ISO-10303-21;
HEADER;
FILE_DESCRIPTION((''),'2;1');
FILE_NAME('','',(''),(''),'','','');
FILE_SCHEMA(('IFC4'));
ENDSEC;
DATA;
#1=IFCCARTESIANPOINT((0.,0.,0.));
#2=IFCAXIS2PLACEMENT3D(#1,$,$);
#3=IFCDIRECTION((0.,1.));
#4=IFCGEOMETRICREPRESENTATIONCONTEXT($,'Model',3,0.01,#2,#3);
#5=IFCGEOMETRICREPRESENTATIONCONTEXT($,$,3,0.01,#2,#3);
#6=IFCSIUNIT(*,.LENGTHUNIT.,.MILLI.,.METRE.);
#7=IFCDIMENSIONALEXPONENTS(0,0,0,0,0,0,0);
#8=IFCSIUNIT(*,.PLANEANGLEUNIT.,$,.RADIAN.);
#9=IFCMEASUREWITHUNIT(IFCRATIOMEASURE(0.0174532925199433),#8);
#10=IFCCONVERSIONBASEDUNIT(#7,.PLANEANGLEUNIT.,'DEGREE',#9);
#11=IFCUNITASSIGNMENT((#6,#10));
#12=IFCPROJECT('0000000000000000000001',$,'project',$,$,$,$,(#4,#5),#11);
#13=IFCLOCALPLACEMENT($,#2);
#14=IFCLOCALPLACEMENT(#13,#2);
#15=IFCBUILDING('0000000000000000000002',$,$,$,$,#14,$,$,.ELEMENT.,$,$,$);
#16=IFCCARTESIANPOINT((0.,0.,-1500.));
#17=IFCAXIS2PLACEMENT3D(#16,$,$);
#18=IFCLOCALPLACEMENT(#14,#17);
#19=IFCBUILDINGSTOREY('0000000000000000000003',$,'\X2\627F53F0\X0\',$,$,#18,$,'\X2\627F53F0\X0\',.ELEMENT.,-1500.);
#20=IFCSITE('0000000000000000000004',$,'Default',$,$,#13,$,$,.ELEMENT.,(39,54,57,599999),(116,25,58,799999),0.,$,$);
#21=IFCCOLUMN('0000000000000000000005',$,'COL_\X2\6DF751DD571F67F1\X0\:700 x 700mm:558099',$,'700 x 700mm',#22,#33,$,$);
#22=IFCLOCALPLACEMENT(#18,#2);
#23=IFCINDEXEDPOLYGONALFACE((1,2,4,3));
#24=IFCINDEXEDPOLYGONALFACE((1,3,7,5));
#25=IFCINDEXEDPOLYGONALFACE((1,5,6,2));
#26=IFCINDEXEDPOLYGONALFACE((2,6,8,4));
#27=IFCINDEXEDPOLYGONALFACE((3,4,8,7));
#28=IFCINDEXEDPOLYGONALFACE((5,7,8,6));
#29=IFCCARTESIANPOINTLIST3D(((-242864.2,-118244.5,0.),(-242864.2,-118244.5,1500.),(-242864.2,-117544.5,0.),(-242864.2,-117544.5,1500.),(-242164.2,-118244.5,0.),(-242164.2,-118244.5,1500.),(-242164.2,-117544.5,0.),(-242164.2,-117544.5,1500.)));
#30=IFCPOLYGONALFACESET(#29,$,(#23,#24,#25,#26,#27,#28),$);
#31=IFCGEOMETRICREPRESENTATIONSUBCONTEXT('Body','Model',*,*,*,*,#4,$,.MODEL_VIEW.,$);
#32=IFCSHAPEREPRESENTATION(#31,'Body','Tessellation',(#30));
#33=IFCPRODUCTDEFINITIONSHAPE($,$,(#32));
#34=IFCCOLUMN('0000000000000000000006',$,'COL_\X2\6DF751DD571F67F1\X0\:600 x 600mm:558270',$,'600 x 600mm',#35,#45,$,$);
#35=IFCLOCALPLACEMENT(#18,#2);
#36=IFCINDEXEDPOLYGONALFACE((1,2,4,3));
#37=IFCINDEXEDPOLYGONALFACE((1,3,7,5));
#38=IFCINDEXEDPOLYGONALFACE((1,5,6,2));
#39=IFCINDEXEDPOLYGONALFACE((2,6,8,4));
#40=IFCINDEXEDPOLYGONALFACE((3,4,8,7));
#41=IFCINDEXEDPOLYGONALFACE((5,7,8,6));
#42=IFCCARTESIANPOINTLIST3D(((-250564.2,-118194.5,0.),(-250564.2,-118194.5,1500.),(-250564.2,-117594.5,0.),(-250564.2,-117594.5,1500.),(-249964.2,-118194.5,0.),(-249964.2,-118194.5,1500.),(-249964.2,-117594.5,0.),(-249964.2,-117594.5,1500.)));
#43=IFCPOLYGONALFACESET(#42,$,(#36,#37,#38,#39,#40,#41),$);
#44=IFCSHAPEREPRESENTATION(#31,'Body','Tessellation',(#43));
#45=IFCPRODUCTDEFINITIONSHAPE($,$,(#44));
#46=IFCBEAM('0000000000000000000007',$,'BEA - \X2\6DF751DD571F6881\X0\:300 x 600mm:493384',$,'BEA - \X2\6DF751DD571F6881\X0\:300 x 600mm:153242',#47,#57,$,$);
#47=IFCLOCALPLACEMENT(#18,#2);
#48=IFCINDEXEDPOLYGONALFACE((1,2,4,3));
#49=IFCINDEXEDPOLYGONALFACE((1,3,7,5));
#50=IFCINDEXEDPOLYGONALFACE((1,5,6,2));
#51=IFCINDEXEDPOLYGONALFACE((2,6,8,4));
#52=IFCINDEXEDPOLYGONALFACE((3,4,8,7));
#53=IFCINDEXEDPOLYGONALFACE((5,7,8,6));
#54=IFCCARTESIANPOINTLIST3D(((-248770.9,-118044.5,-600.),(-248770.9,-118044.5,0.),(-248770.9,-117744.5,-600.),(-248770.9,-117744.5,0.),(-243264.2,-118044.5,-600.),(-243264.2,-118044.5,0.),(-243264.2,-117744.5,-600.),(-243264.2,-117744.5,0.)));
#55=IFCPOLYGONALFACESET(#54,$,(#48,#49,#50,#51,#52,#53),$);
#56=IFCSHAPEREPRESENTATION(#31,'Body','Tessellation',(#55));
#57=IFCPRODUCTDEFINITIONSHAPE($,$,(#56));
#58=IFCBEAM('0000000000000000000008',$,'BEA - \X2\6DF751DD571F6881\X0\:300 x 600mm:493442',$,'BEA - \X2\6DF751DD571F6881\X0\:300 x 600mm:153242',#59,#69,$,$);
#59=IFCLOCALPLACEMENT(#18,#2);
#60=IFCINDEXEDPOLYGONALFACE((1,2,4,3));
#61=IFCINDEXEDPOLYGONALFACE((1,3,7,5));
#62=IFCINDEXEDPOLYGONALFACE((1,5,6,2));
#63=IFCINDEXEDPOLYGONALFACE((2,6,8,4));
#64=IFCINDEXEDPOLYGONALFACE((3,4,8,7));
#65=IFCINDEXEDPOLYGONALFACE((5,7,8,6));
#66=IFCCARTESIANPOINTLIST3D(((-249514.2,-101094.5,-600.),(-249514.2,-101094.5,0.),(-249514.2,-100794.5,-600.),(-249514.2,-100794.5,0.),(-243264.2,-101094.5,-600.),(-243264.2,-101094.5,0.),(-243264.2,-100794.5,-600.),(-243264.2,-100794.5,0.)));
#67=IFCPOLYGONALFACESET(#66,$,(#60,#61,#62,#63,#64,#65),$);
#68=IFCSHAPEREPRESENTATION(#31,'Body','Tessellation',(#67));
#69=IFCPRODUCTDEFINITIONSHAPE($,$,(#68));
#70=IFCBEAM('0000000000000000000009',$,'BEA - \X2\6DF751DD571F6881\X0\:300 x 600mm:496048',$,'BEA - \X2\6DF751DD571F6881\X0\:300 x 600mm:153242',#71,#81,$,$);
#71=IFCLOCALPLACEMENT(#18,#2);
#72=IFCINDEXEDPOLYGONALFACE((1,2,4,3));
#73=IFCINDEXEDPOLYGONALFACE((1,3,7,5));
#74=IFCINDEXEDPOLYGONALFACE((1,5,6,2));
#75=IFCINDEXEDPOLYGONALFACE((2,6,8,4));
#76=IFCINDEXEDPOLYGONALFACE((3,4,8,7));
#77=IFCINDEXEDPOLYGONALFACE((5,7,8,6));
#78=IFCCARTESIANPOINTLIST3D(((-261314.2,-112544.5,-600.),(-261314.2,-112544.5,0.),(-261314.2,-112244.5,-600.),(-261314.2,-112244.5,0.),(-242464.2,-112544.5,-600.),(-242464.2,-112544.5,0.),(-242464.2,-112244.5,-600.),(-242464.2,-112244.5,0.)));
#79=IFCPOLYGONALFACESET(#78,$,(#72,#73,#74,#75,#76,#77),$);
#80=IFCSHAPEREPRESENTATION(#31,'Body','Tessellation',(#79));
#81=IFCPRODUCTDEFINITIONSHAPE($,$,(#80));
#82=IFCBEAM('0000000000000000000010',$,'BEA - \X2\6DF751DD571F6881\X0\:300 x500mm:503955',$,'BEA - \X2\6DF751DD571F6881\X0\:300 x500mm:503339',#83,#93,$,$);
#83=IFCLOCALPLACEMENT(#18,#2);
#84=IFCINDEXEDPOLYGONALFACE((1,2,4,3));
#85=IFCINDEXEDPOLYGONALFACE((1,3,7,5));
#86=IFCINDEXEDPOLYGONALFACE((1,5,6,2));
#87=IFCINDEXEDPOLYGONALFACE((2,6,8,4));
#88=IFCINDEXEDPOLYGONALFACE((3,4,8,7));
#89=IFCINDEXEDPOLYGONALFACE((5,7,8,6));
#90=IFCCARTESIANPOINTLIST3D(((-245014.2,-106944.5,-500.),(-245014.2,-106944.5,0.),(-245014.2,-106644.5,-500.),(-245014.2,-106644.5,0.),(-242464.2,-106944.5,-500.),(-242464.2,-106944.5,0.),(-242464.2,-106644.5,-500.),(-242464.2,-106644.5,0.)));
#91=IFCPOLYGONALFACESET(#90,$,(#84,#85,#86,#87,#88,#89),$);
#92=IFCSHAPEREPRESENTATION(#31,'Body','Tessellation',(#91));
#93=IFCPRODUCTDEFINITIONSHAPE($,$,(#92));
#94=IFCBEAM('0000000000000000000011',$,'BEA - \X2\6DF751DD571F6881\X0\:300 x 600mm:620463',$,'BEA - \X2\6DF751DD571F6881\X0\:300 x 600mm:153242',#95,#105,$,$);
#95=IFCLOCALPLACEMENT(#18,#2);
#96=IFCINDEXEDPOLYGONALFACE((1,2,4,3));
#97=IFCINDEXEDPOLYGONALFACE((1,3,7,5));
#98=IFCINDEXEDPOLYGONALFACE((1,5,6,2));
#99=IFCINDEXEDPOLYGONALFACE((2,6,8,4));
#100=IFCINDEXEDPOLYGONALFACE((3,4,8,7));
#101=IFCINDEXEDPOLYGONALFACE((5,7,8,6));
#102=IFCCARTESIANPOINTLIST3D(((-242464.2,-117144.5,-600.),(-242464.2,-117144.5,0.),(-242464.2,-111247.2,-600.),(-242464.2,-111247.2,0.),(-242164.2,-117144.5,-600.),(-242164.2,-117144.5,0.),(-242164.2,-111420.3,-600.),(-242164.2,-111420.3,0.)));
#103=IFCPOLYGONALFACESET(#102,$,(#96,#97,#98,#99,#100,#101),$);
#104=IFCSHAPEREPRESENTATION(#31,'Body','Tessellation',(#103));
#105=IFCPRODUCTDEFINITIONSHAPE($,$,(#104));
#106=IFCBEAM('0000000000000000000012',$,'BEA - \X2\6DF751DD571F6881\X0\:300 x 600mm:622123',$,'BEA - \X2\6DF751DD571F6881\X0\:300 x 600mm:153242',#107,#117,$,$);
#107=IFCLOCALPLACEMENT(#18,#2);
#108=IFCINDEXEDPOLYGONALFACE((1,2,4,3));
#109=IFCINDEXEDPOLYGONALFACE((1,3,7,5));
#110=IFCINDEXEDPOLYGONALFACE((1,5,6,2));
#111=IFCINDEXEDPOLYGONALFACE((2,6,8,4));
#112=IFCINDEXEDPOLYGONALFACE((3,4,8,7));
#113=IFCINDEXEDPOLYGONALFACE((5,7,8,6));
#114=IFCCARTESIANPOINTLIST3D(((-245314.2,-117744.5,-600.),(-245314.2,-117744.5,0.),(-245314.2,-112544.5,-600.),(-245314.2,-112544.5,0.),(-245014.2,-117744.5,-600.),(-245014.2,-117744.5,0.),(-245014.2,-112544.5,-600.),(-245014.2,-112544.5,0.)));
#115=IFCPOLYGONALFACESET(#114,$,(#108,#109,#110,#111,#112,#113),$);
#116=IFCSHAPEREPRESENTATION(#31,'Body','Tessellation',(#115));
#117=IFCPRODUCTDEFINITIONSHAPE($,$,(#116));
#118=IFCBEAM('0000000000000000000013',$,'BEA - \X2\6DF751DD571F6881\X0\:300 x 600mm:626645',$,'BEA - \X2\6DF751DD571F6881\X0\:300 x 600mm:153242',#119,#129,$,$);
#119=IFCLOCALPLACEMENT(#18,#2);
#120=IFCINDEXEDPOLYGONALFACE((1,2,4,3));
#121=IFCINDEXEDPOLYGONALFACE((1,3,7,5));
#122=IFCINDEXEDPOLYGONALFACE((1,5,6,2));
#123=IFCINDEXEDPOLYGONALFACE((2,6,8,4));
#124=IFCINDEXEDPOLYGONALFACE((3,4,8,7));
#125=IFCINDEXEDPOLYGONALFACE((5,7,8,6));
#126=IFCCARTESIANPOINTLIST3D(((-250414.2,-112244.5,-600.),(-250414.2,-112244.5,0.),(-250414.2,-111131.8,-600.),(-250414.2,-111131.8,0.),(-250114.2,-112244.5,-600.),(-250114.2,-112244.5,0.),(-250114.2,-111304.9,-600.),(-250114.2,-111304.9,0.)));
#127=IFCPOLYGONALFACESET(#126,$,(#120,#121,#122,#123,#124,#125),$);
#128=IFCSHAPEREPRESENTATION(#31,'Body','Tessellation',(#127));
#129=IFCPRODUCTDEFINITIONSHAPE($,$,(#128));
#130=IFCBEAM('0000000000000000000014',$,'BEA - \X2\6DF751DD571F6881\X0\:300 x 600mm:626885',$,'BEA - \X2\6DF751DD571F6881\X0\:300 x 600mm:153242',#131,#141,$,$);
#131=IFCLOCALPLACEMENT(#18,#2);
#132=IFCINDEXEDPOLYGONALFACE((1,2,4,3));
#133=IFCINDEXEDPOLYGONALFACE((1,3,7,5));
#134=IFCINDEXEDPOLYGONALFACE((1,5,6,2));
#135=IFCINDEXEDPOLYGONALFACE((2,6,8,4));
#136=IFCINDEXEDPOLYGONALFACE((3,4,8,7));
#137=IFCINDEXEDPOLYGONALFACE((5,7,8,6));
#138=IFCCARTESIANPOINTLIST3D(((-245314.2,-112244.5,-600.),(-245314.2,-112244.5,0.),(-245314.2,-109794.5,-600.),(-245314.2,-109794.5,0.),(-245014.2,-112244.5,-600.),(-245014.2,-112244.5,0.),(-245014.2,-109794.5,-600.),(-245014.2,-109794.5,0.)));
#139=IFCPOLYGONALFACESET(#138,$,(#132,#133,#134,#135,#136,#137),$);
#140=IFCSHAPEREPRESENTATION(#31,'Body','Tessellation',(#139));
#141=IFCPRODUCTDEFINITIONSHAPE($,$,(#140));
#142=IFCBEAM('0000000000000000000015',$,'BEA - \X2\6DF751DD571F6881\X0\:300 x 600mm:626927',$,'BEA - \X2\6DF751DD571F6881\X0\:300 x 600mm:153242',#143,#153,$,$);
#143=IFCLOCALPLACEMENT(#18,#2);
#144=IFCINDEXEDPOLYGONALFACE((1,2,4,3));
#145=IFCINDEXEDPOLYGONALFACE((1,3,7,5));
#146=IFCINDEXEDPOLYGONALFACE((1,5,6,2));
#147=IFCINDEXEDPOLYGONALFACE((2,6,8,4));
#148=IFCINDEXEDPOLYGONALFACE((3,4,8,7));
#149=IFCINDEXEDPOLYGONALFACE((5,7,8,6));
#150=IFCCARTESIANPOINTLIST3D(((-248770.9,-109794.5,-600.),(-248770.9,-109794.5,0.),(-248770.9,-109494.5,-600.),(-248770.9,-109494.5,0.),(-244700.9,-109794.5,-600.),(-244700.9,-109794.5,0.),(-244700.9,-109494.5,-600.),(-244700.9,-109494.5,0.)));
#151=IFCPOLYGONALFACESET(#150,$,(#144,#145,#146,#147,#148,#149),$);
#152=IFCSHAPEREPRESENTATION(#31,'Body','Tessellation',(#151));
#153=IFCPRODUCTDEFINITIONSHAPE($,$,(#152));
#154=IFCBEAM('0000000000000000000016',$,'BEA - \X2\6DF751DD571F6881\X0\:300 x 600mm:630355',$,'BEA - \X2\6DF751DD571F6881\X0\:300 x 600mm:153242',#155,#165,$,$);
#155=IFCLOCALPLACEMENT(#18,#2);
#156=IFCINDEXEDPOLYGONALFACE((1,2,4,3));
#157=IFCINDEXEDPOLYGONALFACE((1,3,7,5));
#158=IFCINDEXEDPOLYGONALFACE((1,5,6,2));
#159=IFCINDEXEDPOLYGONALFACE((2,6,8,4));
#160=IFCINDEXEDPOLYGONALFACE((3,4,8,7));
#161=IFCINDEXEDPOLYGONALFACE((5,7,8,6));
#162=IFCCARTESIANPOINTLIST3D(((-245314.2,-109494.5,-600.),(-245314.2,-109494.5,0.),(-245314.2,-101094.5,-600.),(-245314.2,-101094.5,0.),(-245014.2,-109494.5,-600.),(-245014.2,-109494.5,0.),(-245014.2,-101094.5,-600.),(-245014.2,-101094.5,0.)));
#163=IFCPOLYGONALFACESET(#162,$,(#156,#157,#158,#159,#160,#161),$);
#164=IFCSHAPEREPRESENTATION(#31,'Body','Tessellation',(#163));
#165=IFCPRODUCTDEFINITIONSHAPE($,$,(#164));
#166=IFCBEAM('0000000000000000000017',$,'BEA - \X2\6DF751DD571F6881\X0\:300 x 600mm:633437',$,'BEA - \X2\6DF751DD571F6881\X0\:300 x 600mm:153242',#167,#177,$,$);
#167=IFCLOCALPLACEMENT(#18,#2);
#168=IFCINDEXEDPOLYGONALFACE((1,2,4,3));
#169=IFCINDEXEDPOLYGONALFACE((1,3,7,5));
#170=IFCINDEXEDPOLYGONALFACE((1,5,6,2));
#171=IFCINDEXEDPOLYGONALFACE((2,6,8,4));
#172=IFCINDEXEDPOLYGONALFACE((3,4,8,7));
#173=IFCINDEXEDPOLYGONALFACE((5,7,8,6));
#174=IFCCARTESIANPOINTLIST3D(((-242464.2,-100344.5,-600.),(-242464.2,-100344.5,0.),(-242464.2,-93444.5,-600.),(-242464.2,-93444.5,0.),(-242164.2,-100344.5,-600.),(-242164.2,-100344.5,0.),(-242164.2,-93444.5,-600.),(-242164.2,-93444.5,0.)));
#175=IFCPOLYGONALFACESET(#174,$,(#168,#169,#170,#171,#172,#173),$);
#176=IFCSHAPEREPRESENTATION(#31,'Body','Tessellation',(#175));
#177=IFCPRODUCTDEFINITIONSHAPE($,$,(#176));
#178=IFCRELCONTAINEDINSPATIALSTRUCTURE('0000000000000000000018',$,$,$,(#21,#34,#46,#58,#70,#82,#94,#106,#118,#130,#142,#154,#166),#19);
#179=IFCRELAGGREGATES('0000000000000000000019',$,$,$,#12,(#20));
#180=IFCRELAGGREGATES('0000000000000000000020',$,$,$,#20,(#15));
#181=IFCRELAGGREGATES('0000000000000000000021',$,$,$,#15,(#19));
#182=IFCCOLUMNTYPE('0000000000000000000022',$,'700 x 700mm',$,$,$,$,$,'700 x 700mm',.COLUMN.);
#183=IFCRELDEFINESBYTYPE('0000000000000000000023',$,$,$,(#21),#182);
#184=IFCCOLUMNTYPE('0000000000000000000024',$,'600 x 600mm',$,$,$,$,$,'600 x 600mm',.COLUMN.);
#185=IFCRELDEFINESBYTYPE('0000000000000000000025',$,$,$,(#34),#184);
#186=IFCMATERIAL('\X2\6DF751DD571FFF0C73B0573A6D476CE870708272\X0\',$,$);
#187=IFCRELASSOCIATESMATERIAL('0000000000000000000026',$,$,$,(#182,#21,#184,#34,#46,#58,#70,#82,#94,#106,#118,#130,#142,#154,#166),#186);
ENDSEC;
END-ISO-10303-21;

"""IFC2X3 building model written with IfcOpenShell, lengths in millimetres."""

from ifc_helpers import new_model, entity, si_unit, converted_unit, direction, frame, frame_2d, origin, origin_2d_with_axis, place, context, subcontext, project, spatial, rectangle, extrude, clip, halfspace, source, transform, mapped, material, type_object, type_shapes, element, save


model = new_model("IFC2X3")

# Units and contexts
model_context = context("Model", 3, precision=0.01, world=origin(), true_north=direction((0.0, 1.0)))
context_of_model = context(None, 3, precision=0.01, world=origin(), true_north=direction((0.0, 1.0)))
body_context = subcontext(model_context, "Body", "Model", "MODEL_VIEW")
ifc_project = project(units=[si_unit("LENGTHUNIT", "METRE", prefix="MILLI"), converted_unit("PLANEANGLEUNIT", "DEGREE", entity("IfcRatioMeasure", 0.0174532925199433), si_unit("PLANEANGLEUNIT", "RADIAN"), dimensions=[0, 0, 0, 0, 0, 0, 0])], contexts=[model_context, context_of_model])

# Site, building, storey
site_placement = place(None, origin())
site = spatial("IfcSite", under=ifc_project, at=site_placement, Name="Default", CompositionType="ELEMENT", RefLatitude=(39, 54, 57, 599999), RefLongitude=(116, 25, 58, 799999), RefElevation=0.0)
building_placement = place(site_placement, origin())
building = spatial("IfcBuilding", under=site, at=building_placement, CompositionType="ELEMENT")
storey_placement = place(building_placement, frame((0.0, 0.0, -1500.0)))
storey = spatial("IfcBuildingStorey", under=building, at=storey_placement, Name="承台", LongName="承台", CompositionType="ELEMENT", Elevation=-1500.0)

# Columns
ifc_material_1 = material(Name="混凝土，现场浇注灰色")
column_type_1 = type_object("IfcColumnType", Name="700 x 700mm", ElementType="700 x 700mm", PredefinedType="COLUMN", material=ifc_material_1)
shared_shape_1 = source(origin(), body_context, "Body", "SweptSolid", [
    extrude(rectangle(XDim=700.0, YDim=700.0, at=frame_2d((0.0, 0.0), x_axis=(1.0, 0.0))), frame((350.0, 350.0, 0.0), z_axis=(0.0, 0.0, 1.0), x_axis=(-1.0, 0.0, 0.0)), (0.0, 0.0, 1.0), 1500.0),
])
type_shapes(column_type_1, [shared_shape_1])
column_1_placement = place(storey_placement, frame((-242864.2, -118244.5, 0.0)))
element("IfcColumn", 1, at=column_1_placement, inside=storey, type_object=column_type_1, material=ifc_material_1, Name="COL_混凝土柱:700 x 700mm:558099", ObjectType="700 x 700mm", context=body_context, shape_type="MappedRepresentation", body=[
    mapped(shared_shape_1, transform((0.0, 0.0, 0.0), scale=1.0)),
])
column_type_2 = type_object("IfcColumnType", Name="600 x 600mm", ElementType="600 x 600mm", PredefinedType="COLUMN", material=ifc_material_1)
shared_shape_2 = source(origin(), body_context, "Body", "SweptSolid", [
    extrude(rectangle(XDim=600.0, YDim=600.0, at=origin_2d_with_axis()), frame((300.0, 300.0, 0.0), z_axis=(0.0, 0.0, 1.0), x_axis=(-1.0, 0.0, 0.0)), (0.0, 0.0, 1.0), 1500.0),
])
type_shapes(column_type_2, [shared_shape_2])
column_2_placement = place(storey_placement, frame((-250564.2, -118194.5, 0.0)))
element("IfcColumn", 2, at=column_2_placement, inside=storey, type_object=column_type_2, material=ifc_material_1, Name="COL_混凝土柱:600 x 600mm:558270", ObjectType="600 x 600mm", context=body_context, shape_type="MappedRepresentation", body=[
    mapped(shared_shape_2, transform((0.0, 0.0, 0.0), scale=1.0)),
])

# Beams
beam_1_placement = place(storey_placement, frame((-243264.2, -117894.5, 0.0), z_axis=(0.0, 0.0, 1.0), x_axis=(-1.0, 0.0, 0.0)))
element("IfcBeam", 3, at=beam_1_placement, inside=storey, material=ifc_material_1, Name="BEA - 混凝土梁:300 x 600mm:493384", ObjectType="BEA - 混凝土梁:300 x 600mm:153242", context=body_context, shape_type="SweptSolid", body=[
    extrude(rectangle(XDim=600.0, YDim=300.0, at=frame_2d((0.0, 0.0), x_axis=(1.0, 0.0))), frame((0.0, 0.0, -300.0), z_axis=(1.0, 0.0, 0.0), x_axis=(0.0, 0.0, -1.0)), (0.0, 0.0, 1.0), 5506.7),
])
beam_2_placement = place(storey_placement, frame((-243264.2, -100944.5, 0.0), z_axis=(0.0, 0.0, 1.0), x_axis=(-1.0, 0.0, 0.0)))
element("IfcBeam", 4, at=beam_2_placement, inside=storey, material=ifc_material_1, Name="BEA - 混凝土梁:300 x 600mm:493442", ObjectType="BEA - 混凝土梁:300 x 600mm:153242", context=body_context, shape_type="SweptSolid", body=[
    extrude(rectangle(XDim=600.0, YDim=300.0, at=frame_2d((0.0, 0.0), x_axis=(1.0, 0.0))), frame((0.0, 0.0, -300.0), z_axis=(1.0, 0.0, 0.0), x_axis=(0.0, 0.0, -1.0)), (0.0, 0.0, 1.0), 6250.0),
])
beam_3_placement = place(storey_placement, frame((-242464.2, -112394.5, 0.0), z_axis=(0.0, 0.0, 1.0), x_axis=(-1.0, 0.0, 0.0)))
element("IfcBeam", 5, at=beam_3_placement, inside=storey, material=ifc_material_1, Name="BEA - 混凝土梁:300 x 600mm:496048", ObjectType="BEA - 混凝土梁:300 x 600mm:153242", context=body_context, shape_type="SweptSolid", body=[
    extrude(rectangle(XDim=600.0, YDim=300.0, at=frame_2d((0.0, 0.0), x_axis=(1.0, 0.0))), frame((0.0, 0.0, -300.0), z_axis=(1.0, 0.0, 0.0), x_axis=(0.0, 0.0, -1.0)), (0.0, 0.0, 1.0), 18850.0),
])
beam_4_placement = place(storey_placement, frame((-245014.2, -106794.5, 0.0)))
element("IfcBeam", 6, at=beam_4_placement, inside=storey, material=ifc_material_1, Name="BEA - 混凝土梁:300 x500mm:503955", ObjectType="BEA - 混凝土梁:300 x500mm:503339", context=body_context, shape_type="SweptSolid", body=[
    extrude(rectangle(XDim=500.0, YDim=300.0, at=frame_2d((0.0, 0.0), x_axis=(1.0, 0.0))), frame((0.0, 0.0, -250.0), z_axis=(1.0, 0.0, 0.0), x_axis=(0.0, 0.0, -1.0)), (0.0, 0.0, 1.0), 2550.0),
])
beam_5_placement = place(storey_placement, frame((-242314.2, -117144.5, 0.0), z_axis=(0.0, 0.0, 1.0), x_axis=(0.0, 1.0, 0.0)))
element("IfcBeam", 7, at=beam_5_placement, inside=storey, material=ifc_material_1, Name="BEA - 混凝土梁:300 x 600mm:620463", ObjectType="BEA - 混凝土梁:300 x 600mm:153242", context=body_context, shape_type="Clipping", body=[
    clip(extrude(rectangle(XDim=600.0, YDim=300.0, at=frame_2d((0.0, 0.0), x_axis=(1.0, 0.0))), frame((0.0, 0.0, -300.0), z_axis=(1.0, 0.0, 0.0), x_axis=(0.0, 0.0, -1.0)), (0.0, 0.0, 1.0), 5897.3), halfspace(frame((7188.0, 2386.7, 0.0), z_axis=(0.866125, -0.499827, 0.0), x_axis=(-0.499827, -0.866125, 0.0)), False)),
])
beam_6_placement = place(storey_placement, frame((-245164.2, -117744.5, 0.0), z_axis=(0.0, 0.0, 1.0), x_axis=(0.0, 1.0, 0.0)))
element("IfcBeam", 8, at=beam_6_placement, inside=storey, material=ifc_material_1, Name="BEA - 混凝土梁:300 x 600mm:622123", ObjectType="BEA - 混凝土梁:300 x 600mm:153242", context=body_context, shape_type="SweptSolid", body=[
    extrude(rectangle(XDim=600.0, YDim=300.0, at=origin_2d_with_axis()), frame((0.0, 0.0, -300.0), z_axis=(1.0, 0.0, 0.0), x_axis=(0.0, 0.0, -1.0)), (0.0, 0.0, 1.0), 5200.0),
])
beam_7_placement = place(storey_placement, frame((-250264.2, -112244.5, 0.0), z_axis=(0.0, 0.0, 1.0), x_axis=(0.0, 1.0, 0.0)))
element("IfcBeam", 9, at=beam_7_placement, inside=storey, material=ifc_material_1, Name="BEA - 混凝土梁:300 x 600mm:626645", ObjectType="BEA - 混凝土梁:300 x 600mm:153242", context=body_context, shape_type="Clipping", body=[
    clip(extrude(rectangle(XDim=600.0, YDim=300.0, at=frame_2d((0.0, 0.0), x_axis=(1.0, 0.0))), frame((0.0, 0.0, -300.0), z_axis=(1.0, 0.0, 0.0), x_axis=(0.0, 0.0, -1.0)), (0.0, 0.0, 1.0), 1112.7), halfspace(frame((2288.0, 2186.7, 0.0), z_axis=(0.866125, -0.499827, 0.0), x_axis=(-0.499827, -0.866125, 0.0)), False)),
])
beam_8_placement = place(storey_placement, frame((-245164.2, -112244.5, 0.0), z_axis=(0.0, 0.0, 1.0), x_axis=(0.0, 1.0, 0.0)))
element("IfcBeam", 10, at=beam_8_placement, inside=storey, material=ifc_material_1, Name="BEA - 混凝土梁:300 x 600mm:626885", ObjectType="BEA - 混凝土梁:300 x 600mm:153242", context=body_context, shape_type="SweptSolid", body=[
    extrude(rectangle(XDim=600.0, YDim=300.0, at=origin_2d_with_axis()), frame((0.0, 0.0, -300.0), z_axis=(1.0, 0.0, 0.0), x_axis=(0.0, 0.0, -1.0)), (0.0, 0.0, 1.0), 2450.0),
])
beam_9_placement = place(storey_placement, frame((-248770.9, -109644.5, 0.0)))
element("IfcBeam", 11, at=beam_9_placement, inside=storey, material=ifc_material_1, Name="BEA - 混凝土梁:300 x 600mm:626927", ObjectType="BEA - 混凝土梁:300 x 600mm:153242", context=body_context, shape_type="SweptSolid", body=[
    extrude(rectangle(XDim=600.0, YDim=300.0, at=frame_2d((0.0, 0.0), x_axis=(1.0, 0.0))), frame((0.0, 0.0, -300.0), z_axis=(1.0, 0.0, 0.0), x_axis=(0.0, 0.0, -1.0)), (0.0, 0.0, 1.0), 4070.0),
])
beam_10_placement = place(storey_placement, frame((-245164.2, -109494.5, 0.0), z_axis=(0.0, 0.0, 1.0), x_axis=(0.0, 1.0, 0.0)))
element("IfcBeam", 12, at=beam_10_placement, inside=storey, material=ifc_material_1, Name="BEA - 混凝土梁:300 x 600mm:630355", ObjectType="BEA - 混凝土梁:300 x 600mm:153242", context=body_context, shape_type="SweptSolid", body=[
    extrude(rectangle(XDim=600.0, YDim=300.0, at=origin_2d_with_axis()), frame((0.0, 0.0, -300.0), z_axis=(1.0, 0.0, 0.0), x_axis=(0.0, 0.0, -1.0)), (0.0, 0.0, 1.0), 8400.0),
])
beam_11_placement = place(storey_placement, frame((-242314.2, -100344.5, 0.0), z_axis=(0.0, 0.0, 1.0), x_axis=(0.0, 1.0, 0.0)))
element("IfcBeam", 13, at=beam_11_placement, inside=storey, material=ifc_material_1, Name="BEA - 混凝土梁:300 x 600mm:633437", ObjectType="BEA - 混凝土梁:300 x 600mm:153242", context=body_context, shape_type="SweptSolid", body=[
    extrude(rectangle(XDim=600.0, YDim=300.0, at=origin_2d_with_axis()), frame((0.0, 0.0, -300.0), z_axis=(1.0, 0.0, 0.0), x_axis=(0.0, 0.0, -1.0)), (0.0, 0.0, 1.0), 6900.0),
])

save(model, "model.ifc")
